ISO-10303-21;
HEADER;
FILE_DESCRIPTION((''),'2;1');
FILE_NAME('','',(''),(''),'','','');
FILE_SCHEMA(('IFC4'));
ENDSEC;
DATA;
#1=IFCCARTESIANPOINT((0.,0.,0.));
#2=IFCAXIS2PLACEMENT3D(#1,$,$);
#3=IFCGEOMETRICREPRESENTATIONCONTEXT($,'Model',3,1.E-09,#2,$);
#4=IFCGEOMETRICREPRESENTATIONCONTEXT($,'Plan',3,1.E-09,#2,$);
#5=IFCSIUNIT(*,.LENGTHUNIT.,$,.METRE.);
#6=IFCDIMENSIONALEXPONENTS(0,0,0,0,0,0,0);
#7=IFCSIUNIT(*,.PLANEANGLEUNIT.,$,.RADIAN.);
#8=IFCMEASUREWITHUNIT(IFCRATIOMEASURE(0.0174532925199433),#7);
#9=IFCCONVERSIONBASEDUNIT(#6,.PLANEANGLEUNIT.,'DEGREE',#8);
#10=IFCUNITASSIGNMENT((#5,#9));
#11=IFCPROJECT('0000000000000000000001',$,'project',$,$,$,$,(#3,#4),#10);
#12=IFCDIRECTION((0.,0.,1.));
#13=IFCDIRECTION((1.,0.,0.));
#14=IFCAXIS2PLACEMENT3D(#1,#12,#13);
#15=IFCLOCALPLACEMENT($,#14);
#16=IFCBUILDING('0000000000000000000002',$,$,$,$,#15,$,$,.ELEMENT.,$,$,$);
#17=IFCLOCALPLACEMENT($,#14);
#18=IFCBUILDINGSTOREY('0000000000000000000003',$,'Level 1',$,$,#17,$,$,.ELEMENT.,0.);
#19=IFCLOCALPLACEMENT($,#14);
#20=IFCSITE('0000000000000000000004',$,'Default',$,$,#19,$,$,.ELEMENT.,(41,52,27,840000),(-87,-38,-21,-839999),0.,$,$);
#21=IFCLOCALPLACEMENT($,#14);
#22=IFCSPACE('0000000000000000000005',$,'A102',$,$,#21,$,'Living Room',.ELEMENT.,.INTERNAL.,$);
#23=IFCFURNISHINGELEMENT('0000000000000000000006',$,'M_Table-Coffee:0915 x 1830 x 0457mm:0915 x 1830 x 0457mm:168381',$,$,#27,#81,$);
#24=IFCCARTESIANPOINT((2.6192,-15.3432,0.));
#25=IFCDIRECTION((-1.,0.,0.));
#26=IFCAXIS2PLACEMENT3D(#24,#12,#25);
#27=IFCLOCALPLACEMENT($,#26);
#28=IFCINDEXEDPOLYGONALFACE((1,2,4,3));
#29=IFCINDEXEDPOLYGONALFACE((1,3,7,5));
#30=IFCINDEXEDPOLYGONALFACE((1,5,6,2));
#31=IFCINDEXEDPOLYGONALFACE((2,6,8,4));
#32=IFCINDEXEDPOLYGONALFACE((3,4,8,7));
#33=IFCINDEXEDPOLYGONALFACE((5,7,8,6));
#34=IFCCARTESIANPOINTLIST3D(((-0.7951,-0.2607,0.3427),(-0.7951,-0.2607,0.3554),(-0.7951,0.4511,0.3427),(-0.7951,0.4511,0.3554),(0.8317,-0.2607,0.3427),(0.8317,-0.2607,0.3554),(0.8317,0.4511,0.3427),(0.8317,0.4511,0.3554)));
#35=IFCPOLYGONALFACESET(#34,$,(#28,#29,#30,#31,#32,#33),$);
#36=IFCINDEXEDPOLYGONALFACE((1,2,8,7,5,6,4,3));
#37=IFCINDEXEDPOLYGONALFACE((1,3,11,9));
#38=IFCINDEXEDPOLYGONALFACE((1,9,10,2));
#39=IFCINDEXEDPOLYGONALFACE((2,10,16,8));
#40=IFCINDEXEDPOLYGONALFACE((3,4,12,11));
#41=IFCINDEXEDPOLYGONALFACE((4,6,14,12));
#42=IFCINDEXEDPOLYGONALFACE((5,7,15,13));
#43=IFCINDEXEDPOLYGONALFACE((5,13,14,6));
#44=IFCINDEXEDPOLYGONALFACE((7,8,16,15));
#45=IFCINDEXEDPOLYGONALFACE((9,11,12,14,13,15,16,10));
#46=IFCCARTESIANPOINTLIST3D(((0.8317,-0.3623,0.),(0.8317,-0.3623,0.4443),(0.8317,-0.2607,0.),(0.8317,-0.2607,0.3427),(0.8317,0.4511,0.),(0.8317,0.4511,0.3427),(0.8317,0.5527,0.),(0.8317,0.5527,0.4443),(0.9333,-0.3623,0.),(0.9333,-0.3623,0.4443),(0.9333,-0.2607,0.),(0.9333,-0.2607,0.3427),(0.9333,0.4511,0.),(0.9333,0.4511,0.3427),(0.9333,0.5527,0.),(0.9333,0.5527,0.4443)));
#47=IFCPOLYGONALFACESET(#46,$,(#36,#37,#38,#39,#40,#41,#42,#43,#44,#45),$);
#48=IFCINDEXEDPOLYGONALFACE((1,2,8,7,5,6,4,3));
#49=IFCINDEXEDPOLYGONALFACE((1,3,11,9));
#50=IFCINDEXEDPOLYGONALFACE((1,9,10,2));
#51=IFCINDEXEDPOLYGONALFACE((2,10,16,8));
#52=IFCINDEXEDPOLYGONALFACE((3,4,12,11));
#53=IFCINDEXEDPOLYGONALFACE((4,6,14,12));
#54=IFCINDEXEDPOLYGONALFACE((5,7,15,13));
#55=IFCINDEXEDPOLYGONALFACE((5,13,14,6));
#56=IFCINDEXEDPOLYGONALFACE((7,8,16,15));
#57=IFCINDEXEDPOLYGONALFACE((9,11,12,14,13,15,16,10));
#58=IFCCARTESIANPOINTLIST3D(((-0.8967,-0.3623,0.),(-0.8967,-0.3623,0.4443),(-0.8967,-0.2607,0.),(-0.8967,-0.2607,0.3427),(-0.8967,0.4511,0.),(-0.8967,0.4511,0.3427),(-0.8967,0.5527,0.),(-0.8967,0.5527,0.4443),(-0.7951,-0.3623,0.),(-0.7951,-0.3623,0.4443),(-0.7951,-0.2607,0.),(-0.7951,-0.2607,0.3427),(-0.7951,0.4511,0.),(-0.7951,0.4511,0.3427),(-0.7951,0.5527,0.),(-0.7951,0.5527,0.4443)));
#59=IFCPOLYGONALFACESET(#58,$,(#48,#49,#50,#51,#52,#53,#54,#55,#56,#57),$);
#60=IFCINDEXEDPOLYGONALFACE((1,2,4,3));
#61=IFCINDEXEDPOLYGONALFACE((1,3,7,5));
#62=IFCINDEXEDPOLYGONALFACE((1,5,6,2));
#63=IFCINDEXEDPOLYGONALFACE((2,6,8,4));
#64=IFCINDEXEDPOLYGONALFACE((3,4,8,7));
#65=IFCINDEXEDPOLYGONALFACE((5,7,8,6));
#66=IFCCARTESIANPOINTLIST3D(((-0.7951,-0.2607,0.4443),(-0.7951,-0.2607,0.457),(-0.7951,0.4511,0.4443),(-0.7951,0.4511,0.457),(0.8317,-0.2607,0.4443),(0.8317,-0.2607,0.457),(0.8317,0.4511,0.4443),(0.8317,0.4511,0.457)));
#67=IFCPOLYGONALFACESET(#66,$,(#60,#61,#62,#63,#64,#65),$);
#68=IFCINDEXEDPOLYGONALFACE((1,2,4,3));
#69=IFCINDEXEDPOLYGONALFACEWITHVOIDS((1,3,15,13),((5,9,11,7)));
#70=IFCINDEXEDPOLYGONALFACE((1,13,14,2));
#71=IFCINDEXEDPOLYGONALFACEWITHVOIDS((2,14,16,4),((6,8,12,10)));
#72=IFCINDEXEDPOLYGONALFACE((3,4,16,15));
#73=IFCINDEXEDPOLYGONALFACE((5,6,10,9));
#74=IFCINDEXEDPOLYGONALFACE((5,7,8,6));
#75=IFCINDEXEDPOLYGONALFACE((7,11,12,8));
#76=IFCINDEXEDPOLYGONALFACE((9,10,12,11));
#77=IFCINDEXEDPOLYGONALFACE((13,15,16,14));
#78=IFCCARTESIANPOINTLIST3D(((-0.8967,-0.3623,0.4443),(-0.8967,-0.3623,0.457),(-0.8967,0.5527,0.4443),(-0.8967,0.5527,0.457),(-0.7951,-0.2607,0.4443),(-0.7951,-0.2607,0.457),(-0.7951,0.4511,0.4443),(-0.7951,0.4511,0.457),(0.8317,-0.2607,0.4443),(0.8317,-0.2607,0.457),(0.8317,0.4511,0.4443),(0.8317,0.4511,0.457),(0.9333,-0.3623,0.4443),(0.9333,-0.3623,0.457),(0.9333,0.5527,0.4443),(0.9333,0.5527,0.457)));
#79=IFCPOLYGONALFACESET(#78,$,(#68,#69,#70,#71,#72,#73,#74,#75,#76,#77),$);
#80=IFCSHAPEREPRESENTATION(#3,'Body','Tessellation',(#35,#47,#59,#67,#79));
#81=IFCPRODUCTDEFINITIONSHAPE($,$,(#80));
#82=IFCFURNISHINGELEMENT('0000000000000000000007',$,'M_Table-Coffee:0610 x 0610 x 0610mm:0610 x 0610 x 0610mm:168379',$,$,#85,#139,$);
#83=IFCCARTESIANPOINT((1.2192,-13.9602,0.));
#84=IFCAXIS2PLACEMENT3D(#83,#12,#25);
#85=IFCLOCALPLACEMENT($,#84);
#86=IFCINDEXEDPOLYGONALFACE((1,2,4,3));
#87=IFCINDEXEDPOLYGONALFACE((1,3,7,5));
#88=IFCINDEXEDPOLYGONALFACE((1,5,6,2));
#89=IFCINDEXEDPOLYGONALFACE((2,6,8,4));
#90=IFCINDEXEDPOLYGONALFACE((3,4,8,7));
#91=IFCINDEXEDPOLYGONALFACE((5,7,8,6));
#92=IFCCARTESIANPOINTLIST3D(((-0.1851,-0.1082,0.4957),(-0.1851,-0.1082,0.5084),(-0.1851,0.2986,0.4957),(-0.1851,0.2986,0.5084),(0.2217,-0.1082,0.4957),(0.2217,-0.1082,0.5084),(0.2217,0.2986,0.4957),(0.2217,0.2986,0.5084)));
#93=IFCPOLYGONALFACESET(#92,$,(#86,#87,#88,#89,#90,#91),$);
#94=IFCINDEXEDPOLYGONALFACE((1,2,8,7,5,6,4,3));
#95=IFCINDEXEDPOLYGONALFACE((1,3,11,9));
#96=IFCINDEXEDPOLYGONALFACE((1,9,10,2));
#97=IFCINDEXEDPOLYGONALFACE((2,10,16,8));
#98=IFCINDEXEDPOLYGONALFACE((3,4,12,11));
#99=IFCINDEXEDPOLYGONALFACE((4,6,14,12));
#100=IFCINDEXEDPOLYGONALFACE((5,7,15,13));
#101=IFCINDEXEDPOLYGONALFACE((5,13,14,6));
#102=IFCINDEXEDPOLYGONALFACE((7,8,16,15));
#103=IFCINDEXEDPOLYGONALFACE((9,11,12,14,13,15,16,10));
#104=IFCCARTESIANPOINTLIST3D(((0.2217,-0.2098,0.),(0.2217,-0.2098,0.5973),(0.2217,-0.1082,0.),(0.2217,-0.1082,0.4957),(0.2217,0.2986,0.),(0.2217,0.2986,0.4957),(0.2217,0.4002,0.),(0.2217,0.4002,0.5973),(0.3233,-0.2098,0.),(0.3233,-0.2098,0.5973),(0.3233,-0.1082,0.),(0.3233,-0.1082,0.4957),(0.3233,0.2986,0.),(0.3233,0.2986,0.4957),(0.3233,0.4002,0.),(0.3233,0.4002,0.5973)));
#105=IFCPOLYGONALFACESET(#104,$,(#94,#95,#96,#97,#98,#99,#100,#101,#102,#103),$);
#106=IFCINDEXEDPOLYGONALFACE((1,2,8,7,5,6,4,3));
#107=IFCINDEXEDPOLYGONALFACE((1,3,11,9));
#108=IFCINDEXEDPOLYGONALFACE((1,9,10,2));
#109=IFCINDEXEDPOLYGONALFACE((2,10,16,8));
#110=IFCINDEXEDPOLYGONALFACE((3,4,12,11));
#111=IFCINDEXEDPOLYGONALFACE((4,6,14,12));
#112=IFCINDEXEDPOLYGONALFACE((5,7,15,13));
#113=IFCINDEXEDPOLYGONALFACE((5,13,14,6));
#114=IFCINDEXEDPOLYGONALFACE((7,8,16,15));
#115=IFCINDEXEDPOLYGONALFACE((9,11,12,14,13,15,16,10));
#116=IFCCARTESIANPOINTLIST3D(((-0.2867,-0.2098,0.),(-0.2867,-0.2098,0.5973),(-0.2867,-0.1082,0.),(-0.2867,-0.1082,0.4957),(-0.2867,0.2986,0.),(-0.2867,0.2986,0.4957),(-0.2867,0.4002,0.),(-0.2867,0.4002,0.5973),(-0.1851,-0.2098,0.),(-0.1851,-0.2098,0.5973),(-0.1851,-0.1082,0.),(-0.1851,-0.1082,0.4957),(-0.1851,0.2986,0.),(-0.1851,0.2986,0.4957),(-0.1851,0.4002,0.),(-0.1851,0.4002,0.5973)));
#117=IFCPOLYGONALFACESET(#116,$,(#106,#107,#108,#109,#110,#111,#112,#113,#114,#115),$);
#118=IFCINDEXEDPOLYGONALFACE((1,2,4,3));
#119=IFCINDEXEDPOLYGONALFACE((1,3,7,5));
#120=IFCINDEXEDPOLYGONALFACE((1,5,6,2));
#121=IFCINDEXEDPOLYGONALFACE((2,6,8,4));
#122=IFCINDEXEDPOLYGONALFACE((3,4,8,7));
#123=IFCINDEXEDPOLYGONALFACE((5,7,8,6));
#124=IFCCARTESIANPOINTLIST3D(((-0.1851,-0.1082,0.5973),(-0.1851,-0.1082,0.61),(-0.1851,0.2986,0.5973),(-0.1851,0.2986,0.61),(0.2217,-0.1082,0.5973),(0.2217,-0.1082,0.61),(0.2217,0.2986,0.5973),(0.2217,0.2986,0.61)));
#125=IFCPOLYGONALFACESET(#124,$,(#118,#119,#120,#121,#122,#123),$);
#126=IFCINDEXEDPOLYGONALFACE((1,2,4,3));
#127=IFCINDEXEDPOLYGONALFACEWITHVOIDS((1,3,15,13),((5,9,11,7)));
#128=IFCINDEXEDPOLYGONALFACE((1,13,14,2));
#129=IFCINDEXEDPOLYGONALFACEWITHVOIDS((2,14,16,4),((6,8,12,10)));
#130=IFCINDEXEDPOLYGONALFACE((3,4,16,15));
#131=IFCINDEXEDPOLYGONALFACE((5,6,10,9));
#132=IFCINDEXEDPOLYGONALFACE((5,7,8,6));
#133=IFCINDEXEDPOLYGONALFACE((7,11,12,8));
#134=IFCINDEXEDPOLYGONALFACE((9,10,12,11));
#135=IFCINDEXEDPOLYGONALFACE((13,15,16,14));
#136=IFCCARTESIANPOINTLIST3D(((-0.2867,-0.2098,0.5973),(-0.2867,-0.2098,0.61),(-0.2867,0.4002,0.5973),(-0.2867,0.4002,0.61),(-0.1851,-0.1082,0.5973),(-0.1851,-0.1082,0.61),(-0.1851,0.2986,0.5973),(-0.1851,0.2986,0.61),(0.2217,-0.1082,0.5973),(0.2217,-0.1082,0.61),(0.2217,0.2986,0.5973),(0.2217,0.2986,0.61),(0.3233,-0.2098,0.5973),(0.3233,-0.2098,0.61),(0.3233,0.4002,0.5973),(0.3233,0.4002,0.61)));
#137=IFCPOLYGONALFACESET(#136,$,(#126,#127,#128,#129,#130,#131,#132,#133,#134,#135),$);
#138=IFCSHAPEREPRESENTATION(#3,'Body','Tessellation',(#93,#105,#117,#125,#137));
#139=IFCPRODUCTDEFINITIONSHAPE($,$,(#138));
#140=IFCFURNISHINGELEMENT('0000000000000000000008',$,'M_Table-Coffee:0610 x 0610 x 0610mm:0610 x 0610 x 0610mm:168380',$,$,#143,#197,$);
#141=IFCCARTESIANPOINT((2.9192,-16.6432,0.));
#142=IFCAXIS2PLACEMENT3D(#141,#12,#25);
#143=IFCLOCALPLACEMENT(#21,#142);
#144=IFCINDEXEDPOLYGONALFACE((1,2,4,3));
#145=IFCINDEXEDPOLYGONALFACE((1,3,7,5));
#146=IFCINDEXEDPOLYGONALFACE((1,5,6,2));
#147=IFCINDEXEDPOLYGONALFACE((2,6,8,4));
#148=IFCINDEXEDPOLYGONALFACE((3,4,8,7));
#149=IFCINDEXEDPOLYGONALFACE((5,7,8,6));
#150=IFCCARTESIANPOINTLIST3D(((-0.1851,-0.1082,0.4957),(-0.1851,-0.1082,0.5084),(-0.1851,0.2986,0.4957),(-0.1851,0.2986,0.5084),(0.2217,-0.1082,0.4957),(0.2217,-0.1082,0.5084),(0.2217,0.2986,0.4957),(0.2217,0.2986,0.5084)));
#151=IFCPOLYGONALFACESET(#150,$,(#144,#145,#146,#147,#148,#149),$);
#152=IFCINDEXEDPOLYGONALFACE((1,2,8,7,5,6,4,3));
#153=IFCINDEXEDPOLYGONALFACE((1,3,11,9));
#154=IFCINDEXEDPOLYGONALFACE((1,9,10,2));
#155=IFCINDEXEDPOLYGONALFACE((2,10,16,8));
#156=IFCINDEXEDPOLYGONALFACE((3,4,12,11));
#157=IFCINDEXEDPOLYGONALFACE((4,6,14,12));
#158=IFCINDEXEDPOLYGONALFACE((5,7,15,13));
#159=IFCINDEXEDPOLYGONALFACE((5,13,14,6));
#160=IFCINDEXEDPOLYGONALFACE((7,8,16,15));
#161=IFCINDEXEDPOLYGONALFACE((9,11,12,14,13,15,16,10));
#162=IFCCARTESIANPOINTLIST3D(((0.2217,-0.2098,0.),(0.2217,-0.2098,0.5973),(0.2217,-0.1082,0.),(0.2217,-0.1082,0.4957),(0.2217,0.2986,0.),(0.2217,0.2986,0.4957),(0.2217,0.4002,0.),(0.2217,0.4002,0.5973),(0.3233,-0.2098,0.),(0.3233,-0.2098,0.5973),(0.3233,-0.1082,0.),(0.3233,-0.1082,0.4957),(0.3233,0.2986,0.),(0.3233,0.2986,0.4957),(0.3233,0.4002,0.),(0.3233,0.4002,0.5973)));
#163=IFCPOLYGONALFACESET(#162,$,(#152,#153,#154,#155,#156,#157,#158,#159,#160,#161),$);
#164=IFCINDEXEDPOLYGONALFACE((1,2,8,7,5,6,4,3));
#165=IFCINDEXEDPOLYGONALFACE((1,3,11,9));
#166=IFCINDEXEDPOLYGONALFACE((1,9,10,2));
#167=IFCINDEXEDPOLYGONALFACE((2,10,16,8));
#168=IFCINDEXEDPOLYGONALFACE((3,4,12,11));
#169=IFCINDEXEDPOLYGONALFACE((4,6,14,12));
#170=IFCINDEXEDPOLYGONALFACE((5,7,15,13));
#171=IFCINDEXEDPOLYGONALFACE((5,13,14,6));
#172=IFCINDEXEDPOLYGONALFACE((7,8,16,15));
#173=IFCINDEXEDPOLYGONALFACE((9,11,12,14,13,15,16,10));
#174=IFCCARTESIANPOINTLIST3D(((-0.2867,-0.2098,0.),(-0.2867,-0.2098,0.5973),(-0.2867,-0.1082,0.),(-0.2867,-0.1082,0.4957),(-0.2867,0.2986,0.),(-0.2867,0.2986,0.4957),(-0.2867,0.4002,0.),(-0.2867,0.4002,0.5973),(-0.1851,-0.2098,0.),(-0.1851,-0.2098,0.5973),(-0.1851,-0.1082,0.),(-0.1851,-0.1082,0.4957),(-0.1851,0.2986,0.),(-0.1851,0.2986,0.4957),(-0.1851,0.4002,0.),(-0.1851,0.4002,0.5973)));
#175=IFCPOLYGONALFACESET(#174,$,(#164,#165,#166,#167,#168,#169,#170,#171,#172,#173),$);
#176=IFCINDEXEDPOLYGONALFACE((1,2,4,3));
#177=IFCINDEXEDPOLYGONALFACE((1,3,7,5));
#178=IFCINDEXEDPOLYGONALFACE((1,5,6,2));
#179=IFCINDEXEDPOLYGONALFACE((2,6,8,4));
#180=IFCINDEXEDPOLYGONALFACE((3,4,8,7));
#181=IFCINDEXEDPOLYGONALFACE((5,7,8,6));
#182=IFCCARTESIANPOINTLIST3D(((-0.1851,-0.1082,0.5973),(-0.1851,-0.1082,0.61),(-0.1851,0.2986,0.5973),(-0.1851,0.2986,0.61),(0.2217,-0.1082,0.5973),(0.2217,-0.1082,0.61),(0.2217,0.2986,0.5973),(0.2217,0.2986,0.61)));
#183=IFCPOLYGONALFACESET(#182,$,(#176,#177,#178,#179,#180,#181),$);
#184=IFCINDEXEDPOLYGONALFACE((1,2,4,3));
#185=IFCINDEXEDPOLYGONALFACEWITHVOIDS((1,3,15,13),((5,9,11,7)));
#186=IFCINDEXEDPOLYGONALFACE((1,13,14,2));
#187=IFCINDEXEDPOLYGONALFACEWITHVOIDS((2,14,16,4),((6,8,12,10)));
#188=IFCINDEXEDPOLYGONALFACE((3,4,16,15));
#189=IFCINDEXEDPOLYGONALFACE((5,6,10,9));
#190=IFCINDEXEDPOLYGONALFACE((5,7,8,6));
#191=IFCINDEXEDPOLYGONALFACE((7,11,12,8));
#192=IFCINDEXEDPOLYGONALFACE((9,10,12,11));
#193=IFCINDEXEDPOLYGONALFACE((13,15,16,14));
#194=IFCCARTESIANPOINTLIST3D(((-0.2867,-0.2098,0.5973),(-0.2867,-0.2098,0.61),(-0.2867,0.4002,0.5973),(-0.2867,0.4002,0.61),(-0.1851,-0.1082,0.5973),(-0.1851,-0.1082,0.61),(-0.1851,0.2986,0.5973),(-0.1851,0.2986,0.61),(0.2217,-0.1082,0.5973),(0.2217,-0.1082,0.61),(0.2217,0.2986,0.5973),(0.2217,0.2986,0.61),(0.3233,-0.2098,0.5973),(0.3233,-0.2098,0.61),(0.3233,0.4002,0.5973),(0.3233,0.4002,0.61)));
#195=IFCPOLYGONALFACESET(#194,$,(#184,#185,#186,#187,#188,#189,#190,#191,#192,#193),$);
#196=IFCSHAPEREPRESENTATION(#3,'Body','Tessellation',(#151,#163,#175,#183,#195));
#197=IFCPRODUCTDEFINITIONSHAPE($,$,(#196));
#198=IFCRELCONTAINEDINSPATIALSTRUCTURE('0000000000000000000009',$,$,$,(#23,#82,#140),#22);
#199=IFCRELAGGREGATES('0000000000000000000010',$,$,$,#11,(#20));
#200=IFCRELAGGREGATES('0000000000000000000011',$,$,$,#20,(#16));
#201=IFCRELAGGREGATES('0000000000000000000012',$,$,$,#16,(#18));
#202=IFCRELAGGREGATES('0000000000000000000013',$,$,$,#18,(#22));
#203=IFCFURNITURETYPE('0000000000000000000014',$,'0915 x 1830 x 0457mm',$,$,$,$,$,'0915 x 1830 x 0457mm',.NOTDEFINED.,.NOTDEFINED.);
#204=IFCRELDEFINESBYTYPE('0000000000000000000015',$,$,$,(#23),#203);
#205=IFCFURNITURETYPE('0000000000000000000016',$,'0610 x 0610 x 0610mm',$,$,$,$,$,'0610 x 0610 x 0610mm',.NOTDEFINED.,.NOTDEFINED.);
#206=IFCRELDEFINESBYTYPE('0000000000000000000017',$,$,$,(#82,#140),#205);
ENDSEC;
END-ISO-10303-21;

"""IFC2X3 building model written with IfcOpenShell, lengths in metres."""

from ifc_helpers import new_model, entity, si_unit, converted_unit, frame, origin, origin_with_axes, origin_2d_with_axis, place, context, project, spatial, polyline, rectangle, outline, extrude, source, transform, mapped, type_object, type_shapes, element, save


model = new_model("IFC2X3")

# Units and contexts
model_context = context("Model", 3, precision=1e-09, world=origin())
plan_context = context("Plan", 3, precision=1e-09, world=origin())
ifc_project = project(units=[si_unit("LENGTHUNIT", "METRE"), converted_unit("PLANEANGLEUNIT", "DEGREE", entity("IfcRatioMeasure", 0.0174532925199433), si_unit("PLANEANGLEUNIT", "RADIAN"), dimensions=[0, 0, 0, 0, 0, 0, 0])], contexts=[model_context, plan_context])

# Site, building, storey, space
site_placement = place(None, origin_with_axes())
site = spatial("IfcSite", under=ifc_project, at=site_placement, Name="Default", CompositionType="ELEMENT", RefLatitude=(41, 52, 27, 840000), RefLongitude=(-87, -38, -21, -839999), RefElevation=0.0)
building_placement = place(None, origin_with_axes())
building = spatial("IfcBuilding", under=site, at=building_placement, CompositionType="ELEMENT")
storey_placement = place(None, origin_with_axes())
storey = spatial("IfcBuildingStorey", under=building, at=storey_placement, Name="Level 1", CompositionType="ELEMENT", Elevation=0.0)
space_placement = place(None, origin_with_axes())
space = spatial("IfcSpace", under=storey, at=space_placement, Name="A102", LongName="Living Room", CompositionType="ELEMENT", InteriorOrExteriorSpace="INTERNAL")

# Furnishing elements
furniture_type_1 = type_object("IfcFurnitureType", Name="0915 x 1830 x 0457mm", ElementType="0915 x 1830 x 0457mm", AssemblyPlace="NOTDEFINED")
shared_shape_1 = source(origin(), model_context, "Body", "SweptSolid", [
    extrude(rectangle(XDim=1.6268, YDim=0.7118, at=origin_2d_with_axis()), frame((0.0183, 0.0952, 0.3427), z_axis=(0.0, 0.0, 1.0), x_axis=(-1.0, 0.0, 0.0)), (0.0, 0.0, 1.0), 0.0127),
    extrude(outline(polyline([(-0.1967, -0.4575), (0.2475, -0.4575), (0.2475, 0.4575), (-0.1967, 0.4575), (-0.1967, 0.3559), (0.146, 0.3559), (0.146, -0.3559), (-0.1967, -0.3559), (-0.1967, -0.4575)])), frame((0.8317, 0.0952, 0.1967), z_axis=(1.0, 0.0, 0.0), x_axis=(0.0, 0.0, 1.0)), (0.0, 0.0, 1.0), 0.1016),
    extrude(outline(polyline([(-0.4575, -0.2476), (0.4575, -0.2476), (0.4575, 0.1968), (0.3559, 0.1968), (0.3559, -0.1459), (-0.3559, -0.1459), (-0.3559, 0.1968), (-0.4575, 0.1968), (-0.4575, -0.2476)])), frame((-0.8967, 0.0952, 0.1968), z_axis=(1.0, 0.0, 0.0), x_axis=(0.0, -1.0, 0.0)), (0.0, 0.0, 1.0), 0.1016),
    extrude(rectangle(XDim=1.6268, YDim=0.7118, at=origin_2d_with_axis()), frame((0.0183, 0.0952, 0.4443), z_axis=(0.0, 0.0, 1.0), x_axis=(-1.0, 0.0, 0.0)), (0.0, 0.0, 1.0), 0.0127),
    extrude(outline(polyline([(-0.915, -0.4575), (0.915, -0.4575), (0.915, 0.4575), (-0.915, 0.4575), (-0.915, -0.4575)]), holes=[polyline([(-0.8134, -0.3559), (-0.8134, 0.3559), (0.8134, 0.3559), (0.8134, -0.3559), (-0.8134, -0.3559)])]), frame((0.0183, 0.0952, 0.4443), z_axis=(0.0, 0.0, 1.0), x_axis=(-1.0, 0.0, 0.0)), (0.0, 0.0, 1.0), 0.0127),
])
type_shapes(furniture_type_1, [shared_shape_1])
furnishing_1_placement = place(None, frame((2.6192, -15.3432, 0.0), z_axis=(0.0, 0.0, 1.0), x_axis=(-1.0, 0.0, 0.0)))
element("IfcFurnishingElement", 1, at=furnishing_1_placement, inside=space, type_object=furniture_type_1, Name="M_Table-Coffee:0915 x 1830 x 0457mm:0915 x 1830 x 0457mm:168381", context=model_context, shape_type="MappedRepresentation", body=[
    mapped(shared_shape_1, transform((0.0, 0.0, 0.0), scale=1.0)),
])
furniture_type_2 = type_object("IfcFurnitureType", Name="0610 x 0610 x 0610mm", ElementType="0610 x 0610 x 0610mm", AssemblyPlace="NOTDEFINED")
shared_shape_2 = source(origin(), model_context, "Body", "SweptSolid", [
    extrude(rectangle(XDim=0.4068, YDim=0.4068, at=origin_2d_with_axis()), frame((0.0183, 0.0952, 0.4957), z_axis=(0.0, 0.0, 1.0), x_axis=(-1.0, 0.0, 0.0)), (0.0, 0.0, 1.0), 0.0127),
    extrude(outline(polyline([(-0.2732, -0.305), (0.324, -0.305), (0.324, 0.305), (-0.2732, 0.305), (-0.2732, 0.2034), (0.2225, 0.2034), (0.2225, -0.2034), (-0.2732, -0.2034), (-0.2732, -0.305)])), frame((0.2217, 0.0952, 0.2732), z_axis=(1.0, 0.0, 0.0), x_axis=(0.0, 0.0, 1.0)), (0.0, 0.0, 1.0), 0.1016),
    extrude(outline(polyline([(-0.305, -0.3241), (0.305, -0.3241), (0.305, 0.2733), (0.2034, 0.2733), (0.2034, -0.2224), (-0.2034, -0.2224), (-0.2034, 0.2733), (-0.305, 0.2733), (-0.305, -0.3241)])), frame((-0.2867, 0.0952, 0.2733), z_axis=(1.0, 0.0, 0.0), x_axis=(0.0, -1.0, 0.0)), (0.0, 0.0, 1.0), 0.1016),
    extrude(rectangle(XDim=0.4068, YDim=0.4068, at=origin_2d_with_axis()), frame((0.0183, 0.0952, 0.5973), z_axis=(0.0, 0.0, 1.0), x_axis=(-1.0, 0.0, 0.0)), (0.0, 0.0, 1.0), 0.0127),
    extrude(outline(polyline([(-0.305, -0.305), (0.305, -0.305), (0.305, 0.305), (-0.305, 0.305), (-0.305, -0.305)]), holes=[polyline([(-0.2034, -0.2034), (-0.2034, 0.2034), (0.2034, 0.2034), (0.2034, -0.2034), (-0.2034, -0.2034)])]), frame((0.0183, 0.0952, 0.5973), z_axis=(0.0, 0.0, 1.0), x_axis=(-1.0, 0.0, 0.0)), (0.0, 0.0, 1.0), 0.0127),
])
type_shapes(furniture_type_2, [shared_shape_2])
furnishing_2_placement = place(None, frame((1.2192, -13.9602, 0.0), z_axis=(0.0, 0.0, 1.0), x_axis=(-1.0, 0.0, 0.0)))
element("IfcFurnishingElement", 2, at=furnishing_2_placement, inside=space, type_object=furniture_type_2, Name="M_Table-Coffee:0610 x 0610 x 0610mm:0610 x 0610 x 0610mm:168379", context=model_context, shape_type="MappedRepresentation", body=[
    mapped(shared_shape_2, transform((0.0, 0.0, 0.0), scale=1.0)),
])
furnishing_3_placement = place(space_placement, frame((2.9192, -16.6432, 0.0), z_axis=(0.0, 0.0, 1.0), x_axis=(-1.0, 0.0, 0.0)))
element("IfcFurnishingElement", 3, at=furnishing_3_placement, inside=space, type_object=furniture_type_2, Name="M_Table-Coffee:0610 x 0610 x 0610mm:0610 x 0610 x 0610mm:168380", context=model_context, shape_type="MappedRepresentation", body=[
    mapped(shared_shape_2, transform((0.0, 0.0, 0.0), scale=1.0)),
])

save(model, "model.ifc")
